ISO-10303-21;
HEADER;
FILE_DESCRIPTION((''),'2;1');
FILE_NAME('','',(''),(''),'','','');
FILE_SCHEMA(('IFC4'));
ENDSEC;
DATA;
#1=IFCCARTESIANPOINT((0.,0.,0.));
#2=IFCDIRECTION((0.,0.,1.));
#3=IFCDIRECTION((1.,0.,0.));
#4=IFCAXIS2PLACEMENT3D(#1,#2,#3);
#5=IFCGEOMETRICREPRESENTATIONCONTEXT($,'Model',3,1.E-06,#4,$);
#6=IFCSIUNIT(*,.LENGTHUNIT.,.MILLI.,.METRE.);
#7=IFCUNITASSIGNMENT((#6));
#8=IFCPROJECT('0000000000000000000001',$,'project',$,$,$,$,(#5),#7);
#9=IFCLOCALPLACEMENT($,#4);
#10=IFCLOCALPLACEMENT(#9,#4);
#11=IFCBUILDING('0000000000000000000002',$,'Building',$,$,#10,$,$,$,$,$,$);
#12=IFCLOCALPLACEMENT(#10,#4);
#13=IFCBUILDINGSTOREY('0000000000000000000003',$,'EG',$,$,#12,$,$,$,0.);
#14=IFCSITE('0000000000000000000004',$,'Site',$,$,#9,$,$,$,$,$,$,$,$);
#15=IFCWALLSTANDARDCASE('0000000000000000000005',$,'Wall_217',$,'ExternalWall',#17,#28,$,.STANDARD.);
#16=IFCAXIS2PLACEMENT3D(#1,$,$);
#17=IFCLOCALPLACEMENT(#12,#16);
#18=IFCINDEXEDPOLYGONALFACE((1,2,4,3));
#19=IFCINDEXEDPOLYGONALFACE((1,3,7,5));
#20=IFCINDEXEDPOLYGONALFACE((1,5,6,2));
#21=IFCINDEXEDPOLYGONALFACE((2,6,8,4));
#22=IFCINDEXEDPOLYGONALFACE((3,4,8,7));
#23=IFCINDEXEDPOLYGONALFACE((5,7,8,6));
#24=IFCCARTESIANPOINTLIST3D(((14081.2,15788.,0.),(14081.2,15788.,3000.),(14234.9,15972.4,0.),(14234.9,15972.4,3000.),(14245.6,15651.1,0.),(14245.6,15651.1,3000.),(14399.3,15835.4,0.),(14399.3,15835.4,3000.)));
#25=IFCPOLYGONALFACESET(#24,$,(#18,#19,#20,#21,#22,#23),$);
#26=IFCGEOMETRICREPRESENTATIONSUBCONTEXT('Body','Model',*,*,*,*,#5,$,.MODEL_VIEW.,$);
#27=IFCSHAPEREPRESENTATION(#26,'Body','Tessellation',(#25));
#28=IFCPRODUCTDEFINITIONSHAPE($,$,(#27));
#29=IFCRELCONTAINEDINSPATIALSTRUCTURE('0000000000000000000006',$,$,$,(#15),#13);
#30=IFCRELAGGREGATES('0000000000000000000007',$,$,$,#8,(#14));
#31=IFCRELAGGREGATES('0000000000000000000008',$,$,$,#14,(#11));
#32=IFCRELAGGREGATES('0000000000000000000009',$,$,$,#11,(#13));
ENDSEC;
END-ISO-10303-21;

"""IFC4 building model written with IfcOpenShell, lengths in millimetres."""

from ifc_helpers import new_model, si_unit, frame, origin_with_axes, place, context, subcontext, project, spatial, rectangle, extrude, element, save


model = new_model("IFC4")

# Units and contexts
model_context = context("Model", 3, precision=1e-06, world=origin_with_axes())
body_context = subcontext(model_context, "Body", "Model", "MODEL_VIEW")
ifc_project = project(units=[si_unit("LENGTHUNIT", "METRE", prefix="MILLI")], contexts=[model_context])

# Site, building, storey
site_placement = place(None, origin_with_axes())
site = spatial("IfcSite", under=ifc_project, at=site_placement, Name="Site")
building_placement = place(site_placement, origin_with_axes())
building = spatial("IfcBuilding", under=site, at=building_placement, Name="Building")
storey_placement = place(building_placement, origin_with_axes())
storey = spatial("IfcBuildingStorey", under=building, at=storey_placement, Name="EG", Elevation=0.0)

# Wall
wall_1_placement = place(storey_placement, origin_with_axes())
element("IfcWallStandardCase", 1, at=wall_1_placement, inside=storey, Name="Wall_217", ObjectType="ExternalWall", PredefinedType="STANDARD", context=body_context, shape_type="SweptSolid", body=[
    extrude(rectangle(XDim=214.0, YDim=240.0), frame((14240.2, 15811.7, 0.0), z_axis=(0.0, 0.0, 1.0), x_axis=(-0.768221, 0.640184, 0.0)), (0.0, 0.0, 1.0), 3000.0),
])

save(model, "model.ifc")
